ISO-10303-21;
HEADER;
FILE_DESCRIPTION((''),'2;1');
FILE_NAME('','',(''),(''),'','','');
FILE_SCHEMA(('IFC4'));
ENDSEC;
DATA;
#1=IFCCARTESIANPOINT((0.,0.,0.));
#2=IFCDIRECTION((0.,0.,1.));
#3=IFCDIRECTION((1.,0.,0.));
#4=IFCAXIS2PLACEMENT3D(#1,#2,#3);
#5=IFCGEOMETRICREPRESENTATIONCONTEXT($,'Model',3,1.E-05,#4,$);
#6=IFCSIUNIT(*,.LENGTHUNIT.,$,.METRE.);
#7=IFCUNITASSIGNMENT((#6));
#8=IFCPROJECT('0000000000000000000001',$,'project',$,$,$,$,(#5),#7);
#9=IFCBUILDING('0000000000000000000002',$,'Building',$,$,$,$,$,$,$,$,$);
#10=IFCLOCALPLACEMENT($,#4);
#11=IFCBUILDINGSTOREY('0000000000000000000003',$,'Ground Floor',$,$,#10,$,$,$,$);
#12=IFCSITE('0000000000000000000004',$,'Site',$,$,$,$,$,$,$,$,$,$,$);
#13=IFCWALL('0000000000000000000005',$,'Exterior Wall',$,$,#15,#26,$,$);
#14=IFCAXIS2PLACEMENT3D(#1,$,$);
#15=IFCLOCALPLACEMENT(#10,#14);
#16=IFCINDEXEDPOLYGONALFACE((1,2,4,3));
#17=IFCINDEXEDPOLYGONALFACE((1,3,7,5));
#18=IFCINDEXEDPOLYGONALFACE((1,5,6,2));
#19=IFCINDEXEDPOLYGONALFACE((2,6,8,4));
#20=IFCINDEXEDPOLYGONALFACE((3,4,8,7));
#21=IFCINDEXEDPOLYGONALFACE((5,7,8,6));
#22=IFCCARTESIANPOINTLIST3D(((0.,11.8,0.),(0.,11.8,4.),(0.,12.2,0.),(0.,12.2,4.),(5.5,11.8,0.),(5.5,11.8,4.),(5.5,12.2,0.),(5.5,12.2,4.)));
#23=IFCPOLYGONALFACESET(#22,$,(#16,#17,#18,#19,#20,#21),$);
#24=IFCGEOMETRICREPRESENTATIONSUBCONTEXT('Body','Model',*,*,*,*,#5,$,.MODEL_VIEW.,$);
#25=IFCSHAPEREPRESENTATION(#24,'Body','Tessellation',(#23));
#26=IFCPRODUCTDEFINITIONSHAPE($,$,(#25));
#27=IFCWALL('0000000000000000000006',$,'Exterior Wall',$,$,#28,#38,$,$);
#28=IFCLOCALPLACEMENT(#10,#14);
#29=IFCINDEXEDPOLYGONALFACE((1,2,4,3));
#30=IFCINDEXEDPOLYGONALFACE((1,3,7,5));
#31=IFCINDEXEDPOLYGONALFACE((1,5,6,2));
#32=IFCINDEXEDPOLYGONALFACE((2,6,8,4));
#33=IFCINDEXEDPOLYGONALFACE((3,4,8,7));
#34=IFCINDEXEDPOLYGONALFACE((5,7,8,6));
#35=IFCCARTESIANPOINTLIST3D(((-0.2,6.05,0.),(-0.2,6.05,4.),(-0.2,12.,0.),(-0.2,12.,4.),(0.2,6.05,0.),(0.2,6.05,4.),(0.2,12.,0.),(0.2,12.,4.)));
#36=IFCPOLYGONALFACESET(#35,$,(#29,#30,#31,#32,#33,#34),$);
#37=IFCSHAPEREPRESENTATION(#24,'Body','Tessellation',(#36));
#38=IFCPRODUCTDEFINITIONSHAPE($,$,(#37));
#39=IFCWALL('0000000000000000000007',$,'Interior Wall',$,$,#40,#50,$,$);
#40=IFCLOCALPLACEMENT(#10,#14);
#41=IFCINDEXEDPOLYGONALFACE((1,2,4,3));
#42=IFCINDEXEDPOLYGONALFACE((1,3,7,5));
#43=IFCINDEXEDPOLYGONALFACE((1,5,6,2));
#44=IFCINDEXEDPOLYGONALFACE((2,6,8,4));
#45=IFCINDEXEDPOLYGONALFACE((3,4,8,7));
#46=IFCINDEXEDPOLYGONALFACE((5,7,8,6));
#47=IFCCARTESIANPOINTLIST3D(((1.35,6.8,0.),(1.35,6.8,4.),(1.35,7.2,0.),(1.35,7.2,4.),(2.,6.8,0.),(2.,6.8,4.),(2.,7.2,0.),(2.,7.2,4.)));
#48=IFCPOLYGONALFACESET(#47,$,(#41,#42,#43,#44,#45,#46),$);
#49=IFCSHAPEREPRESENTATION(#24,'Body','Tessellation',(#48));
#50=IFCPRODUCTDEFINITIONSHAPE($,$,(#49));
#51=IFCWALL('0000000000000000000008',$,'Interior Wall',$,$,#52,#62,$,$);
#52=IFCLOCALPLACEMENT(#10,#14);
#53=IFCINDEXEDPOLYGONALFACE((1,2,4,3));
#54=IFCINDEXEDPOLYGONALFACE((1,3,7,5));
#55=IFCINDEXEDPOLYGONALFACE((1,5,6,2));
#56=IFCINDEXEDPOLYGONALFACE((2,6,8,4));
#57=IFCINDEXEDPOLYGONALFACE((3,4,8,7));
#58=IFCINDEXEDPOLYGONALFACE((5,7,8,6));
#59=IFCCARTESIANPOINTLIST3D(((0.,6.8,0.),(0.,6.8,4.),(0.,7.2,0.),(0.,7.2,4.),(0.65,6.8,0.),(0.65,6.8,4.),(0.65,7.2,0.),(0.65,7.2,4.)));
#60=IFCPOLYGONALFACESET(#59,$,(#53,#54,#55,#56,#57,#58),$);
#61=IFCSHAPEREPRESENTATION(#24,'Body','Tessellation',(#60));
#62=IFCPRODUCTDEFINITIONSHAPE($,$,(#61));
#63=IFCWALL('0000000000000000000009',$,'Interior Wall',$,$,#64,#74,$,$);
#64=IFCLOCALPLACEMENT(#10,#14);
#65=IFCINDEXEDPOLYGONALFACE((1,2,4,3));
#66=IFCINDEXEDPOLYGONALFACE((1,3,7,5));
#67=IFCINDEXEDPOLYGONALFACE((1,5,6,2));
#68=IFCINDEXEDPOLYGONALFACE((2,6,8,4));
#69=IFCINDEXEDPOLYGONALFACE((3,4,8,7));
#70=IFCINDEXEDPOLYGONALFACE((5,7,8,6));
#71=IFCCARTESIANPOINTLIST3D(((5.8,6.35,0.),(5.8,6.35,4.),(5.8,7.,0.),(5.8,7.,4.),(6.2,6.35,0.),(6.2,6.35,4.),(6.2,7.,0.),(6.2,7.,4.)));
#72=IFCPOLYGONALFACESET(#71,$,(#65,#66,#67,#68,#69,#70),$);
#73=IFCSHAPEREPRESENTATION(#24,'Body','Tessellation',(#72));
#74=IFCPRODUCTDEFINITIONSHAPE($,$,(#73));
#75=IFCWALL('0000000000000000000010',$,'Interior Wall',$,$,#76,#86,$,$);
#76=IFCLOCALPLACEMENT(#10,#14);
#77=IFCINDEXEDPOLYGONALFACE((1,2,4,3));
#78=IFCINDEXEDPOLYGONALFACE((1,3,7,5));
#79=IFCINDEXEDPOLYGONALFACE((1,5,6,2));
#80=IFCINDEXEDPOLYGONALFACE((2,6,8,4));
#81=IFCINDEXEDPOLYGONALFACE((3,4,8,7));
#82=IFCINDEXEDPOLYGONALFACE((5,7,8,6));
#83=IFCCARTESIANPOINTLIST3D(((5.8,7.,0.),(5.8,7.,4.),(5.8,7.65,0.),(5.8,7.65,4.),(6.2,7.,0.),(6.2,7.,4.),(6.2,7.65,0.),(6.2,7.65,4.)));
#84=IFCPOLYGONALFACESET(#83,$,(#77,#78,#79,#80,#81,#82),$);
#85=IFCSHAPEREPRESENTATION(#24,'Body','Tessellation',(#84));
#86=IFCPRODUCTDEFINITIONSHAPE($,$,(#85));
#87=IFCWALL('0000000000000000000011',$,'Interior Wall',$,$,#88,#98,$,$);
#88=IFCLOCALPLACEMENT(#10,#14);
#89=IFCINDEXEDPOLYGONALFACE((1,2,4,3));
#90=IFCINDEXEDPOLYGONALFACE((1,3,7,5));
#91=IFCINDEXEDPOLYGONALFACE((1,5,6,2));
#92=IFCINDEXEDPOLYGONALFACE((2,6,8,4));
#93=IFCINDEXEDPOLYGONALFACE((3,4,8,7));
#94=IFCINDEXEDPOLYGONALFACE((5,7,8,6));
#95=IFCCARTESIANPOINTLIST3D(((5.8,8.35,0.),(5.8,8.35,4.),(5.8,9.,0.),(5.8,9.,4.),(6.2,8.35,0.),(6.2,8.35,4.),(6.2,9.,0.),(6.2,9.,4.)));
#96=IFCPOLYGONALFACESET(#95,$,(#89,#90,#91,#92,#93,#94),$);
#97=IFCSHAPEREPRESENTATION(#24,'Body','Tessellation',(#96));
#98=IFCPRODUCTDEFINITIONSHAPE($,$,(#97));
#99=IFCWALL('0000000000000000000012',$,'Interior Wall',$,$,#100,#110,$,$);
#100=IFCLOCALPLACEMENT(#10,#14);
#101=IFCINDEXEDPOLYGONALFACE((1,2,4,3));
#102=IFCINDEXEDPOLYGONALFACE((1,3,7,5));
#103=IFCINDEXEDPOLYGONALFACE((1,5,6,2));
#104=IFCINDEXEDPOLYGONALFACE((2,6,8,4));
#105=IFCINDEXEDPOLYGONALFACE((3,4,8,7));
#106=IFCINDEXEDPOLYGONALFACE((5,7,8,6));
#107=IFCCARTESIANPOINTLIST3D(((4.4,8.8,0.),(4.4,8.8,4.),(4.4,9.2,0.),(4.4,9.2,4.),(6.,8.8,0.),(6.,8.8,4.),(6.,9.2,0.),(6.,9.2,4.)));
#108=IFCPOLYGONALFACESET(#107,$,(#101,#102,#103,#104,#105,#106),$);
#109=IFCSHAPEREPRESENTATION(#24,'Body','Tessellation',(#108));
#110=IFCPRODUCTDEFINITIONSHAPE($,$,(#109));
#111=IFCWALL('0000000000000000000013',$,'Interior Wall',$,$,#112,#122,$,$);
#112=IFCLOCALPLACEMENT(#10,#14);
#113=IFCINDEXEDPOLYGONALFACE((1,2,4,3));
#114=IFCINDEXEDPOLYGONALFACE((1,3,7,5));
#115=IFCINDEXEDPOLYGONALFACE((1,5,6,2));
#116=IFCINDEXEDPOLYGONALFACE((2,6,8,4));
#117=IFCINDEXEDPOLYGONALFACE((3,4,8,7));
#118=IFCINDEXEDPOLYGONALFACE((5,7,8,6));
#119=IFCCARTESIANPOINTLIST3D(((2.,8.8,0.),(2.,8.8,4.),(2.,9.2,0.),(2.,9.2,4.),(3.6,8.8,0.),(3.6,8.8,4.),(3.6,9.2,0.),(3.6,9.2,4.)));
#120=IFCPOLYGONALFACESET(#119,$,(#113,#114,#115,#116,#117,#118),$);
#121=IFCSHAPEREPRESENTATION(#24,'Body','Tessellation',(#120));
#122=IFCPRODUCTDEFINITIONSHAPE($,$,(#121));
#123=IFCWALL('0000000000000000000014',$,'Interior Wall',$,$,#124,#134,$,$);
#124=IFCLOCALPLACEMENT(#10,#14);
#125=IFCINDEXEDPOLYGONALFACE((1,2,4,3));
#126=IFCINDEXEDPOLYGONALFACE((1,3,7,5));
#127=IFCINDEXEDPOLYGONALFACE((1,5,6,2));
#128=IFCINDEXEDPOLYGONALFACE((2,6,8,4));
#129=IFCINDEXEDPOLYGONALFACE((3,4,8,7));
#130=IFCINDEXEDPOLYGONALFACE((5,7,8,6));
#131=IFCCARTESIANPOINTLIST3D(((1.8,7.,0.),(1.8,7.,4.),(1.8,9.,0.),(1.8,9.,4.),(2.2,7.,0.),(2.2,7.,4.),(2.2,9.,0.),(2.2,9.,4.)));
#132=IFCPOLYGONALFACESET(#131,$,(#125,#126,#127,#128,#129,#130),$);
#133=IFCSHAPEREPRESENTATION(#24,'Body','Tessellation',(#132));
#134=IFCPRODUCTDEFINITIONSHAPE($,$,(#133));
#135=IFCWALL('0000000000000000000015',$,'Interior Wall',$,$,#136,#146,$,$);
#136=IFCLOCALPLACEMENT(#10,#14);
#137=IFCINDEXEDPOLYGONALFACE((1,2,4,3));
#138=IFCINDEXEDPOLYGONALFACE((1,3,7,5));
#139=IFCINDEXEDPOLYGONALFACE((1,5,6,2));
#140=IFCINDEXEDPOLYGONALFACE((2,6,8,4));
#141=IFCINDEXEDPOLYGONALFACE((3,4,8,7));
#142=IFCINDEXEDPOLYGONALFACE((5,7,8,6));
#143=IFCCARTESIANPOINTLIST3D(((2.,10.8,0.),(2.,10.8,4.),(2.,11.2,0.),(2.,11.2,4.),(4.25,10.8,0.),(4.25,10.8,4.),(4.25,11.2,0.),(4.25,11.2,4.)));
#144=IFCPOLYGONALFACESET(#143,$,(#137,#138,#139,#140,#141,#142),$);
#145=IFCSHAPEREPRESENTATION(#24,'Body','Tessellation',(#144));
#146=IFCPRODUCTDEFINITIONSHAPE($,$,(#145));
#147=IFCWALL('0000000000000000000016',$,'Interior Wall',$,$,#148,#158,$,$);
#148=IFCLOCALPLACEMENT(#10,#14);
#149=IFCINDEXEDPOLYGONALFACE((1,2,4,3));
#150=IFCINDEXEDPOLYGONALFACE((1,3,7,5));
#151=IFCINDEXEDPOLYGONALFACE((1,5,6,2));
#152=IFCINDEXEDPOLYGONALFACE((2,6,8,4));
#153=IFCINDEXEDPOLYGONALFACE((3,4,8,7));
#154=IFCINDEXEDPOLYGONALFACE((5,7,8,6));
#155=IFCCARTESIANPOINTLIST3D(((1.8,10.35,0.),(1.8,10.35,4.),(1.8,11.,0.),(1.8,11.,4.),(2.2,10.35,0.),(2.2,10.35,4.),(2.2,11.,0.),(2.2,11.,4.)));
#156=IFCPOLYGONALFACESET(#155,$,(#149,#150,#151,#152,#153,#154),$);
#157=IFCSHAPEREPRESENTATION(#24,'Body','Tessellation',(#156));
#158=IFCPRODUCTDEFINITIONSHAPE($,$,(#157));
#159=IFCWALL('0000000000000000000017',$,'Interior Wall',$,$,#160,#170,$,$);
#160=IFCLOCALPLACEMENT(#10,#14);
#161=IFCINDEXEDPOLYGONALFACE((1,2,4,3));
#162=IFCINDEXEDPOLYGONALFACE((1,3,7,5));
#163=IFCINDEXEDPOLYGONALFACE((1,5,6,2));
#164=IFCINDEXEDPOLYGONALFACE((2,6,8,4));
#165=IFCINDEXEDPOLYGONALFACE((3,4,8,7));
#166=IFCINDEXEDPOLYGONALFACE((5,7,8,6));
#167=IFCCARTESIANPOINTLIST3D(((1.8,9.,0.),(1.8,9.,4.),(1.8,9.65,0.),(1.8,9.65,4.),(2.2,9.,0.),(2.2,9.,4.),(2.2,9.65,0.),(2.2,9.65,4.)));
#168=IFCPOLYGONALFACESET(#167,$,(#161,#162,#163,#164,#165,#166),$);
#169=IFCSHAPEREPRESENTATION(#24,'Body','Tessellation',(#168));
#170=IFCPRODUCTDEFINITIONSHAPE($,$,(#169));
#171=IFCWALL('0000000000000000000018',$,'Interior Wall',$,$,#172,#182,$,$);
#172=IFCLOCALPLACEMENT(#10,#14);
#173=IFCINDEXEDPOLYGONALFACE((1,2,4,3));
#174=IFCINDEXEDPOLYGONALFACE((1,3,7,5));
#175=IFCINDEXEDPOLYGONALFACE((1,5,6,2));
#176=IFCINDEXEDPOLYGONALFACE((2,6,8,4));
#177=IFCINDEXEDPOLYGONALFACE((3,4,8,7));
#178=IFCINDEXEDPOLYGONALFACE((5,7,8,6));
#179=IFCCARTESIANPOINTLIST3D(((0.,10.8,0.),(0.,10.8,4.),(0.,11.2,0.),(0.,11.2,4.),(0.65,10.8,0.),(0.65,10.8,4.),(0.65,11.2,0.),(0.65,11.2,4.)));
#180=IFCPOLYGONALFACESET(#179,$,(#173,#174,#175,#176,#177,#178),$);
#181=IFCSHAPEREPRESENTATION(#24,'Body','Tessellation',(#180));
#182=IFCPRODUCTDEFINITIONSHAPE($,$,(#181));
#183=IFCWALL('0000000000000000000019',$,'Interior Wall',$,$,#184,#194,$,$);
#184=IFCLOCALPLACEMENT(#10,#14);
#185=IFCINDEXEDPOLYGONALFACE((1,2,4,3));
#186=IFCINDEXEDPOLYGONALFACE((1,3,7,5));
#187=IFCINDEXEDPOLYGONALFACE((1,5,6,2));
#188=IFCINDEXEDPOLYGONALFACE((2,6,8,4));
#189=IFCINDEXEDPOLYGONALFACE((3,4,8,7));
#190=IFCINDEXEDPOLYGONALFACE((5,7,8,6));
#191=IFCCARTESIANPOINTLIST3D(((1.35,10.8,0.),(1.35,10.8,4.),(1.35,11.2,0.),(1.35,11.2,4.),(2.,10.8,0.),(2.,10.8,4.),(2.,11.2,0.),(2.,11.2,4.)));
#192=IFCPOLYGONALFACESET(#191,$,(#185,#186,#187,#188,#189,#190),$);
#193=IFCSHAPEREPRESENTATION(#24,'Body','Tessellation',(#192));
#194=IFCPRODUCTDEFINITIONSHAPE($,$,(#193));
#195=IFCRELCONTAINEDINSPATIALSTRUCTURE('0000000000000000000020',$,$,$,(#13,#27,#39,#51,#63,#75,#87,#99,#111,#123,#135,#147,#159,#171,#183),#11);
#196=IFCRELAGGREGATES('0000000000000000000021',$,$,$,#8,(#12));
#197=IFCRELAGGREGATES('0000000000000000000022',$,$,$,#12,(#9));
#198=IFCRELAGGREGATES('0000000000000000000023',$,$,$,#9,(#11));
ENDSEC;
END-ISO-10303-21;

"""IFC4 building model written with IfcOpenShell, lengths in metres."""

from ifc_helpers import new_model, si_unit, frame, origin_with_axes, place, context, subcontext, project, spatial, indexed_curve, outline, extrude, element, save


model = new_model("IFC4")

# Units and contexts
model_context = context("Model", 3, precision=1e-05, world=origin_with_axes())
body_context = subcontext(model_context, "Body", "Model", "MODEL_VIEW")
ifc_project = project(units=[si_unit("LENGTHUNIT", "METRE")], contexts=[model_context])

# Site, building, storey
site = spatial("IfcSite", under=ifc_project, Name="Site")
building = spatial("IfcBuilding", under=site, Name="Building")
storey_placement = place(None, origin_with_axes())
storey = spatial("IfcBuildingStorey", under=building, at=storey_placement, Name="Ground Floor")

# Walls
wall_1_placement = place(storey_placement, frame((5.5, 12.0, 0.0), z_axis=(0.0, 0.0, 1.0), x_axis=(-1.0, 0.0, 0.0)))
element("IfcWall", 1, at=wall_1_placement, inside=storey, Name="Exterior Wall", context=body_context, shape_type="SweptSolid", body=[
    extrude(outline(indexed_curve([(0.0, 0.0), (0.0, 0.4), (5.5, 0.4), (5.5, 0.0), (0.0, 0.0)], self_intersect=False)), frame((0.0, -0.2, 0.0), z_axis=(0.0, 0.0, 1.0), x_axis=(1.0, 0.0, 0.0)), (0.0, 0.0, 1.0), 4.0),
])
wall_2_placement = place(storey_placement, frame((0.0, 12.0, 0.0), z_axis=(0.0, 0.0, 1.0), x_axis=(0.0, -1.0, 0.0)))
element("IfcWall", 2, at=wall_2_placement, inside=storey, Name="Exterior Wall", context=body_context, shape_type="SweptSolid", body=[
    extrude(outline(indexed_curve([(0.0, 0.0), (0.0, 0.4), (5.95, 0.4), (5.95, 0.0), (0.0, 0.0)], self_intersect=False)), frame((0.0, -0.2, 0.0), z_axis=(0.0, 0.0, 1.0), x_axis=(1.0, 0.0, 0.0)), (0.0, 0.0, 1.0), 4.0),
])
for number, where, z_axis, x_axis, name in (
    (3, (2.0, 7.0, 0.0), (0.0, 0.0, 1.0), (-1.0, 0.0, 0.0), "Interior Wall"),
    (4, (0.65, 7.0, 0.0), (0.0, 0.0, 1.0), (-1.0, 0.0, 0.0), "Interior Wall"),
):
    element("IfcWall", number, at=place(storey_placement, frame(where, z_axis=z_axis, x_axis=x_axis)), inside=storey, Name=name, context=body_context, shape_type="SweptSolid", body=[
        extrude(outline(indexed_curve([(0.0, 0.0), (0.0, 0.4), (0.65, 0.4), (0.65, 0.0), (0.0, 0.0)], self_intersect=False)), frame((0.0, -0.2, 0.0), z_axis=(0.0, 0.0, 1.0), x_axis=(1.0, 0.0, 0.0)), (0.0, 0.0, 1.0), 4.0),
    ])
for number, where, z_axis, x_axis, name in (
    (5, (6.0, 6.35, 0.0), (0.0, 0.0, 1.0), (0.0, 1.0, 0.0), "Interior Wall"),
    (6, (6.0, 7.0, 0.0), (0.0, 0.0, 1.0), (0.0, 1.0, 0.0), "Interior Wall"),
    (7, (6.0, 8.35, 0.0), (0.0, 0.0, 1.0), (0.0, 1.0, 0.0), "Interior Wall"),
):
    element("IfcWall", number, at=place(storey_placement, frame(where, z_axis=z_axis, x_axis=x_axis)), inside=storey, Name=name, context=body_context, shape_type="SweptSolid", body=[
        extrude(outline(indexed_curve([(0.0, 0.0), (0.0, 0.4), (0.65, 0.4), (0.65, 0.0), (0.0, 0.0)], self_intersect=False)), frame((0.0, -0.2, 0.0), z_axis=(0.0, 0.0, 1.0), x_axis=(1.0, 0.0, 0.0)), (0.0, 0.0, 1.0), 4.0),
    ])
wall_3_placement = place(storey_placement, frame((6.0, 9.0, 0.0), z_axis=(0.0, 0.0, 1.0), x_axis=(-1.0, 0.0, 0.0)))
element("IfcWall", 8, at=wall_3_placement, inside=storey, Name="Interior Wall", context=body_context, shape_type="SweptSolid", body=[
    extrude(outline(indexed_curve([(0.0, 0.0), (0.0, 0.4), (1.6, 0.4), (1.6, 0.0), (0.0, 0.0)], self_intersect=False)), frame((0.0, -0.2, 0.0), z_axis=(0.0, 0.0, 1.0), x_axis=(1.0, 0.0, 0.0)), (0.0, 0.0, 1.0), 4.0),
])
wall_4_placement = place(storey_placement, frame((3.6, 9.0, 0.0), z_axis=(0.0, 0.0, 1.0), x_axis=(-1.0, 0.0, 0.0)))
element("IfcWall", 9, at=wall_4_placement, inside=storey, Name="Interior Wall", context=body_context, shape_type="SweptSolid", body=[
    extrude(outline(indexed_curve([(0.0, 0.0), (0.0, 0.4), (1.6, 0.4), (1.6, 0.0), (0.0, 0.0)], self_intersect=False)), frame((0.0, -0.2, 0.0), z_axis=(0.0, 0.0, 1.0), x_axis=(1.0, 0.0, 0.0)), (0.0, 0.0, 1.0), 4.0),
])
wall_5_placement = place(storey_placement, frame((2.0, 9.0, 0.0), z_axis=(0.0, 0.0, 1.0), x_axis=(0.0, -1.0, 0.0)))
element("IfcWall", 10, at=wall_5_placement, inside=storey, Name="Interior Wall", context=body_context, shape_type="SweptSolid", body=[
    extrude(outline(indexed_curve([(0.0, 0.0), (0.0, 0.4), (2.0, 0.4), (2.0, 0.0), (0.0, 0.0)], self_intersect=False)), frame((0.0, -0.2, 0.0), z_axis=(0.0, 0.0, 1.0), x_axis=(1.0, 0.0, 0.0)), (0.0, 0.0, 1.0), 4.0),
])
wall_6_placement = place(storey_placement, frame((4.25, 11.0, 0.0), z_axis=(0.0, 0.0, 1.0), x_axis=(-1.0, 0.0, 0.0)))
element("IfcWall", 11, at=wall_6_placement, inside=storey, Name="Interior Wall", context=body_context, shape_type="SweptSolid", body=[
    extrude(outline(indexed_curve([(0.0, 0.0), (0.0, 0.4), (2.25, 0.4), (2.25, 0.0), (0.0, 0.0)], self_intersect=False)), frame((0.0, -0.2, 0.0), z_axis=(0.0, 0.0, 1.0), x_axis=(1.0, 0.0, 0.0)), (0.0, 0.0, 1.0), 4.0),
])
for number, where, z_axis, x_axis, name in (
    (12, (2.0, 11.0, 0.0), (0.0, 0.0, 1.0), (0.0, -1.0, 0.0), "Interior Wall"),
    (13, (2.0, 9.65, 0.0), (0.0, 0.0, 1.0), (0.0, -1.0, 0.0), "Interior Wall"),
):
    element("IfcWall", number, at=place(storey_placement, frame(where, z_axis=z_axis, x_axis=x_axis)), inside=storey, Name=name, context=body_context, shape_type="SweptSolid", body=[
        extrude(outline(indexed_curve([(0.0, 0.0), (0.0, 0.4), (0.65, 0.4), (0.65, 0.0), (0.0, 0.0)], self_intersect=False)), frame((0.0, -0.2, 0.0), z_axis=(0.0, 0.0, 1.0), x_axis=(1.0, 0.0, 0.0)), (0.0, 0.0, 1.0), 4.0),
    ])
wall_7_placement = place(storey_placement, frame((0.0, 11.0, 0.0), z_axis=(0.0, 0.0, 1.0), x_axis=(1.0, 0.0, 0.0)))
element("IfcWall", 14, at=wall_7_placement, inside=storey, Name="Interior Wall", context=body_context, shape_type="SweptSolid", body=[
    extrude(outline(indexed_curve([(0.0, 0.0), (0.0, 0.4), (0.65, 0.4), (0.65, 0.0), (0.0, 0.0)], self_intersect=False)), frame((0.0, -0.2, 0.0), z_axis=(0.0, 0.0, 1.0), x_axis=(1.0, 0.0, 0.0)), (0.0, 0.0, 1.0), 4.0),
])
wall_8_placement = place(storey_placement, frame((1.35, 11.0, 0.0), z_axis=(0.0, 0.0, 1.0), x_axis=(1.0, 0.0, 0.0)))
element("IfcWall", 15, at=wall_8_placement, inside=storey, Name="Interior Wall", context=body_context, shape_type="SweptSolid", body=[
    extrude(outline(indexed_curve([(0.0, 0.0), (0.0, 0.4), (0.65, 0.4), (0.65, 0.0), (0.0, 0.0)], self_intersect=False)), frame((0.0, -0.2, 0.0), z_axis=(0.0, 0.0, 1.0), x_axis=(1.0, 0.0, 0.0)), (0.0, 0.0, 1.0), 4.0),
])

save(model, "model.ifc")
